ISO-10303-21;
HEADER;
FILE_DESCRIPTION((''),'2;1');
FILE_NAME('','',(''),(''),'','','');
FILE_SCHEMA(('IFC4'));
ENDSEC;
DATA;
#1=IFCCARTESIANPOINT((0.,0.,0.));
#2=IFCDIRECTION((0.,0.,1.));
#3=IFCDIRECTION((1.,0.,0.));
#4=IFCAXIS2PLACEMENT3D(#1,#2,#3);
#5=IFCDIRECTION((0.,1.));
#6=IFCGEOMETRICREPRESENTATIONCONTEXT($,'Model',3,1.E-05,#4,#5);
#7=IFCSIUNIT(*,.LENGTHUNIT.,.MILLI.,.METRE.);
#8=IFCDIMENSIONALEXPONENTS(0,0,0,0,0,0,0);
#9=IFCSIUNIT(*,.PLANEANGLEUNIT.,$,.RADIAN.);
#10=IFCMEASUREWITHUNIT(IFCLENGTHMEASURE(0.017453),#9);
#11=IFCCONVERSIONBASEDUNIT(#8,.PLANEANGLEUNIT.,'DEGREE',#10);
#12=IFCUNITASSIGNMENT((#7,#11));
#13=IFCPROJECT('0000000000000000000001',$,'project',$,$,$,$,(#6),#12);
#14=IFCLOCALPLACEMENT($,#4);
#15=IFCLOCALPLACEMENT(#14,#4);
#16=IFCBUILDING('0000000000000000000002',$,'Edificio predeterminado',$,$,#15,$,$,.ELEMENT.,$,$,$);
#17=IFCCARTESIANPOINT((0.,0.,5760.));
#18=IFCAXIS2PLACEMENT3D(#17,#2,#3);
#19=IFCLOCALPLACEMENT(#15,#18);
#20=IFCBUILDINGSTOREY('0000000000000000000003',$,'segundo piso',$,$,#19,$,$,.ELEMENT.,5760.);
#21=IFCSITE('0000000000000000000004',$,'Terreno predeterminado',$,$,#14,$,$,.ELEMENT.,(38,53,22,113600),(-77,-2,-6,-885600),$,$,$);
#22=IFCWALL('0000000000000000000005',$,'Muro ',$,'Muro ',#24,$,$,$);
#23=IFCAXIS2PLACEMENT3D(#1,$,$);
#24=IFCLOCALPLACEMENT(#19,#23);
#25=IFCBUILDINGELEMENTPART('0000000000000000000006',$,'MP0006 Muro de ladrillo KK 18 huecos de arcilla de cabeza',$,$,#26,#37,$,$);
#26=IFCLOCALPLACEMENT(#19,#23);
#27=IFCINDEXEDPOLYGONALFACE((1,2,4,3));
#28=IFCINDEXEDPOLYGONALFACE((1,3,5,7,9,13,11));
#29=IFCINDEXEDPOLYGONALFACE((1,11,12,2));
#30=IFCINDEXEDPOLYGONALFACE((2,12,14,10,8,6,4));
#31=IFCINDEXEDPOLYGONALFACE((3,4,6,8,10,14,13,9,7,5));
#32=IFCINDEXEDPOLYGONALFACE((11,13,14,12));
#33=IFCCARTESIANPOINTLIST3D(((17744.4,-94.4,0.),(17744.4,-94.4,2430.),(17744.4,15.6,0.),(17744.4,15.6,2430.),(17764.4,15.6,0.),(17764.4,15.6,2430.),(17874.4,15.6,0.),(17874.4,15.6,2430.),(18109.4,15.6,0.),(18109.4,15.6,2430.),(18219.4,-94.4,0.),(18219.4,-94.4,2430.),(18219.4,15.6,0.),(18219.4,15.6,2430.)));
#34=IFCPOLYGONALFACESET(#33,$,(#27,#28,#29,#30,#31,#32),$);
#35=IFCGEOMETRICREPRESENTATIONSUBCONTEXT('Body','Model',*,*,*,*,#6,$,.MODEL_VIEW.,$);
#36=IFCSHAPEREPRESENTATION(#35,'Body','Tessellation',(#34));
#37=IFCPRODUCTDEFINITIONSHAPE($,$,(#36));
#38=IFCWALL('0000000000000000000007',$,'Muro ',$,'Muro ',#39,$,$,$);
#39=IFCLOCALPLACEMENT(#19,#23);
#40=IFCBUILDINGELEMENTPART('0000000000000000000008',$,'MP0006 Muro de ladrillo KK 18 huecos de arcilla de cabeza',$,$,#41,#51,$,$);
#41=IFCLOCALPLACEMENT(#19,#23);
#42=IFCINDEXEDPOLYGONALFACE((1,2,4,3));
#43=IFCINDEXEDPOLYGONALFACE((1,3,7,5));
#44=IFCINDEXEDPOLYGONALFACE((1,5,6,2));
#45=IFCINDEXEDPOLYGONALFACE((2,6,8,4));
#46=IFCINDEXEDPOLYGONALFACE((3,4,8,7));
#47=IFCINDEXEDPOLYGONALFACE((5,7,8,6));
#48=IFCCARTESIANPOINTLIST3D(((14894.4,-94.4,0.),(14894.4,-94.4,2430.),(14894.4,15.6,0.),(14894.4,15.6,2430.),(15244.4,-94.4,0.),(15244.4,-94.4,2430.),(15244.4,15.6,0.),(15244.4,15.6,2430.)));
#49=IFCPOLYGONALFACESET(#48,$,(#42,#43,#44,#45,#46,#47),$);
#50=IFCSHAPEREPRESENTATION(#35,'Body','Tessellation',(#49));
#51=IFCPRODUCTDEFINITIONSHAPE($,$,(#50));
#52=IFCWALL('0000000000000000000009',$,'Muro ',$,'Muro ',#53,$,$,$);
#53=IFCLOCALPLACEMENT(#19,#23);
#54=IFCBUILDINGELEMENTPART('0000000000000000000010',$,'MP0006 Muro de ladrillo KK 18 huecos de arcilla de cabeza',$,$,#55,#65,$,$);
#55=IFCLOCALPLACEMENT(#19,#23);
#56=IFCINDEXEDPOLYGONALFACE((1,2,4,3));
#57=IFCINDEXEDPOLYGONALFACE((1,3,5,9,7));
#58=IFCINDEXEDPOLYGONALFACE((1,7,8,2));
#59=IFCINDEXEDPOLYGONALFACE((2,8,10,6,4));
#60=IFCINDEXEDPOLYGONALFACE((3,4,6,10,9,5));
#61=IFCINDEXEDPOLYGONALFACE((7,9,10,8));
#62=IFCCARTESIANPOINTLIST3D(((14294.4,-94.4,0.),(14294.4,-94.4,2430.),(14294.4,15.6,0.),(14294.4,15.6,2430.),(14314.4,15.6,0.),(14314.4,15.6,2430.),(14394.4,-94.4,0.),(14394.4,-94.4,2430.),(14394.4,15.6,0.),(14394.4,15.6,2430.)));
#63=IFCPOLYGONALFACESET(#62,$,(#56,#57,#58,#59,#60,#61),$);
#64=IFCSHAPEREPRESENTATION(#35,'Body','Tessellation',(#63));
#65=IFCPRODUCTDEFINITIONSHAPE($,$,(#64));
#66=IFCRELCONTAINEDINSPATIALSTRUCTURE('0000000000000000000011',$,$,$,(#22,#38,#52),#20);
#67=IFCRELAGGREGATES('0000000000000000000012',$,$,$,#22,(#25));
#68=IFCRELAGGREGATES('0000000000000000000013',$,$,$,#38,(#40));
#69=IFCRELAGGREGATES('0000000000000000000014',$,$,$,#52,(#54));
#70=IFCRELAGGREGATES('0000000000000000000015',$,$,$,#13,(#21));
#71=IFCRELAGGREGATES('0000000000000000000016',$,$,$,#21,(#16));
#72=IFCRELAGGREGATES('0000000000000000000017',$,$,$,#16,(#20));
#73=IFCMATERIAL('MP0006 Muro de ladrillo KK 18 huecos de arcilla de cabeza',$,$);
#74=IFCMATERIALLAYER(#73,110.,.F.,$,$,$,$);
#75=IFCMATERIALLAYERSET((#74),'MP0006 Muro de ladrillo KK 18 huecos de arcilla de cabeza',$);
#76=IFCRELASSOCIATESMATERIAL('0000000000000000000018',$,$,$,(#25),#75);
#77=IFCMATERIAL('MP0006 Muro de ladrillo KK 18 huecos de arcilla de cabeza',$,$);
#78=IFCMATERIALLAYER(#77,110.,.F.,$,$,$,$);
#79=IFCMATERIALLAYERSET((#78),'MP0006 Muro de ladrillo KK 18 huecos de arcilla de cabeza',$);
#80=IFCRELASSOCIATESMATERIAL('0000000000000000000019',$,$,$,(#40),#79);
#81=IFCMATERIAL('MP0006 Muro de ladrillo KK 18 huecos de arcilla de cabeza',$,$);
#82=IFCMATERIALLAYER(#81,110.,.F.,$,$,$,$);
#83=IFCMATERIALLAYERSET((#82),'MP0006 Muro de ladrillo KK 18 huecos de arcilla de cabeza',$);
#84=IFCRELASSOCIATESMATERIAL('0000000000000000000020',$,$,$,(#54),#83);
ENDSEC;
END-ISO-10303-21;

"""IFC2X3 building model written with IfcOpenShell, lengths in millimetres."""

from ifc_helpers import new_model, entity, si_unit, converted_unit, direction, frame, origin_with_axes, place, context, subcontext, project, spatial, polyline, outline, extrude, material, layer, layer_set, layer_usage, element, aggregate, save


model = new_model("IFC2X3")

# Units and contexts
model_context = context("Model", 3, precision=1e-05, world=origin_with_axes(), true_north=direction((0.0, 1.0)))
body_context = subcontext(model_context, "Body", "Model", "MODEL_VIEW")
ifc_project = project(units=[si_unit("LENGTHUNIT", "METRE", prefix="MILLI"), converted_unit("PLANEANGLEUNIT", "DEGREE", entity("IfcLengthMeasure", 0.017453), si_unit("PLANEANGLEUNIT", "RADIAN"), dimensions=[0, 0, 0, 0, 0, 0, 0])], contexts=[model_context])

# Site, building, storey
site_placement = place(None, origin_with_axes())
site = spatial("IfcSite", under=ifc_project, at=site_placement, Name="Terreno predeterminado", CompositionType="ELEMENT", RefLatitude=(38, 53, 22, 113600), RefLongitude=(-77, -2, -6, -885600))
building_placement = place(site_placement, origin_with_axes())
building = spatial("IfcBuilding", under=site, at=building_placement, Name="Edificio predeterminado", CompositionType="ELEMENT")
storey_placement = place(building_placement, frame((0.0, 0.0, 5760.0), z_axis=(0.0, 0.0, 1.0), x_axis=(1.0, 0.0, 0.0)))
storey = spatial("IfcBuildingStorey", under=building, at=storey_placement, Name="segundo piso", CompositionType="ELEMENT", Elevation=5760.0)

# Walls, building element parts
wall_1_placement = place(storey_placement, frame((18164.4, -39.4, 0.0), z_axis=(0.0, 0.0, 1.0), x_axis=(-1.0, 0.0, 0.0)))
wall_1 = element("IfcWall", 1, at=wall_1_placement, inside=storey, Name="Muro ", ObjectType="Muro ")
ifc_material_1 = material(Name="MP0006 Muro de ladrillo KK 18 huecos de arcilla de cabeza")
ifc_layer_1 = layer(ifc_material_1, 110.0, ventilated=False)
ifc_layer_set_1 = layer_set([ifc_layer_1], Name="MP0006 Muro de ladrillo KK 18 huecos de arcilla de cabeza")
ifc_layer_usage_1 = layer_usage(ifc_layer_set_1, "AXIS2", "NEGATIVE", -55.0)
building_element_part_1_placement = place(wall_1_placement, origin_with_axes())
building_element_part_1 = element("IfcBuildingElementPart", 2, at=building_element_part_1_placement, material=ifc_layer_usage_1, Name="MP0006 Muro de ladrillo KK 18 huecos de arcilla de cabeza", context=body_context, shape_type="SweptSolid", body=[
    extrude(outline(polyline([(420.0, 55.0), (420.0, -55.0), (400.0, -55.0), (290.0, -55.0), (55.0, -55.0), (-55.0, -55.0), (-55.0, 55.0), (420.0, 55.0)])), origin_with_axes(), (0.0, 0.0, 1.0), 2430.0),
])
aggregate(wall_1, [building_element_part_1])
wall_2_placement = place(storey_placement, frame((15244.4, -39.4, 0.0), z_axis=(0.0, 0.0, 1.0), x_axis=(-1.0, 0.0, 0.0)))
wall_2 = element("IfcWall", 3, at=wall_2_placement, inside=storey, Name="Muro ", ObjectType="Muro ")
ifc_material_2 = material(Name="MP0006 Muro de ladrillo KK 18 huecos de arcilla de cabeza")
ifc_layer_2 = layer(ifc_material_2, 110.0, ventilated=False)
ifc_layer_set_2 = layer_set([ifc_layer_2], Name="MP0006 Muro de ladrillo KK 18 huecos de arcilla de cabeza")
ifc_layer_usage_2 = layer_usage(ifc_layer_set_2, "AXIS2", "NEGATIVE", -55.0)
building_element_part_2_placement = place(wall_2_placement, origin_with_axes())
building_element_part_2 = element("IfcBuildingElementPart", 4, at=building_element_part_2_placement, material=ifc_layer_usage_2, Name="MP0006 Muro de ladrillo KK 18 huecos de arcilla de cabeza", context=body_context, shape_type="SweptSolid", body=[
    extrude(outline(polyline([(350.0, 55.0), (350.0, -55.0), (0.0, -55.0), (0.0, 55.0), (350.0, 55.0)])), origin_with_axes(), (0.0, 0.0, 1.0), 2430.0),
])
aggregate(wall_2, [building_element_part_2])
wall_3_placement = place(storey_placement, frame((14394.4, -39.4, 0.0), z_axis=(0.0, 0.0, 1.0), x_axis=(-1.0, 0.0, 0.0)))
wall_3 = element("IfcWall", 5, at=wall_3_placement, inside=storey, Name="Muro ", ObjectType="Muro ")
ifc_material_3 = material(Name="MP0006 Muro de ladrillo KK 18 huecos de arcilla de cabeza")
ifc_layer_3 = layer(ifc_material_3, 110.0, ventilated=False)
ifc_layer_set_3 = layer_set([ifc_layer_3], Name="MP0006 Muro de ladrillo KK 18 huecos de arcilla de cabeza")
ifc_layer_usage_3 = layer_usage(ifc_layer_set_3, "AXIS2", "NEGATIVE", -55.0)
building_element_part_3_placement = place(wall_3_placement, origin_with_axes())
building_element_part_3 = element("IfcBuildingElementPart", 6, at=building_element_part_3_placement, material=ifc_layer_usage_3, Name="MP0006 Muro de ladrillo KK 18 huecos de arcilla de cabeza", context=body_context, shape_type="SweptSolid", body=[
    extrude(outline(polyline([(100.0, 55.0), (100.0, -55.0), (80.0, -55.0), (0.0, -55.0), (0.0, 55.0), (100.0, 55.0)])), origin_with_axes(), (0.0, 0.0, 1.0), 2430.0),
])
aggregate(wall_3, [building_element_part_3])

save(model, "model.ifc")
